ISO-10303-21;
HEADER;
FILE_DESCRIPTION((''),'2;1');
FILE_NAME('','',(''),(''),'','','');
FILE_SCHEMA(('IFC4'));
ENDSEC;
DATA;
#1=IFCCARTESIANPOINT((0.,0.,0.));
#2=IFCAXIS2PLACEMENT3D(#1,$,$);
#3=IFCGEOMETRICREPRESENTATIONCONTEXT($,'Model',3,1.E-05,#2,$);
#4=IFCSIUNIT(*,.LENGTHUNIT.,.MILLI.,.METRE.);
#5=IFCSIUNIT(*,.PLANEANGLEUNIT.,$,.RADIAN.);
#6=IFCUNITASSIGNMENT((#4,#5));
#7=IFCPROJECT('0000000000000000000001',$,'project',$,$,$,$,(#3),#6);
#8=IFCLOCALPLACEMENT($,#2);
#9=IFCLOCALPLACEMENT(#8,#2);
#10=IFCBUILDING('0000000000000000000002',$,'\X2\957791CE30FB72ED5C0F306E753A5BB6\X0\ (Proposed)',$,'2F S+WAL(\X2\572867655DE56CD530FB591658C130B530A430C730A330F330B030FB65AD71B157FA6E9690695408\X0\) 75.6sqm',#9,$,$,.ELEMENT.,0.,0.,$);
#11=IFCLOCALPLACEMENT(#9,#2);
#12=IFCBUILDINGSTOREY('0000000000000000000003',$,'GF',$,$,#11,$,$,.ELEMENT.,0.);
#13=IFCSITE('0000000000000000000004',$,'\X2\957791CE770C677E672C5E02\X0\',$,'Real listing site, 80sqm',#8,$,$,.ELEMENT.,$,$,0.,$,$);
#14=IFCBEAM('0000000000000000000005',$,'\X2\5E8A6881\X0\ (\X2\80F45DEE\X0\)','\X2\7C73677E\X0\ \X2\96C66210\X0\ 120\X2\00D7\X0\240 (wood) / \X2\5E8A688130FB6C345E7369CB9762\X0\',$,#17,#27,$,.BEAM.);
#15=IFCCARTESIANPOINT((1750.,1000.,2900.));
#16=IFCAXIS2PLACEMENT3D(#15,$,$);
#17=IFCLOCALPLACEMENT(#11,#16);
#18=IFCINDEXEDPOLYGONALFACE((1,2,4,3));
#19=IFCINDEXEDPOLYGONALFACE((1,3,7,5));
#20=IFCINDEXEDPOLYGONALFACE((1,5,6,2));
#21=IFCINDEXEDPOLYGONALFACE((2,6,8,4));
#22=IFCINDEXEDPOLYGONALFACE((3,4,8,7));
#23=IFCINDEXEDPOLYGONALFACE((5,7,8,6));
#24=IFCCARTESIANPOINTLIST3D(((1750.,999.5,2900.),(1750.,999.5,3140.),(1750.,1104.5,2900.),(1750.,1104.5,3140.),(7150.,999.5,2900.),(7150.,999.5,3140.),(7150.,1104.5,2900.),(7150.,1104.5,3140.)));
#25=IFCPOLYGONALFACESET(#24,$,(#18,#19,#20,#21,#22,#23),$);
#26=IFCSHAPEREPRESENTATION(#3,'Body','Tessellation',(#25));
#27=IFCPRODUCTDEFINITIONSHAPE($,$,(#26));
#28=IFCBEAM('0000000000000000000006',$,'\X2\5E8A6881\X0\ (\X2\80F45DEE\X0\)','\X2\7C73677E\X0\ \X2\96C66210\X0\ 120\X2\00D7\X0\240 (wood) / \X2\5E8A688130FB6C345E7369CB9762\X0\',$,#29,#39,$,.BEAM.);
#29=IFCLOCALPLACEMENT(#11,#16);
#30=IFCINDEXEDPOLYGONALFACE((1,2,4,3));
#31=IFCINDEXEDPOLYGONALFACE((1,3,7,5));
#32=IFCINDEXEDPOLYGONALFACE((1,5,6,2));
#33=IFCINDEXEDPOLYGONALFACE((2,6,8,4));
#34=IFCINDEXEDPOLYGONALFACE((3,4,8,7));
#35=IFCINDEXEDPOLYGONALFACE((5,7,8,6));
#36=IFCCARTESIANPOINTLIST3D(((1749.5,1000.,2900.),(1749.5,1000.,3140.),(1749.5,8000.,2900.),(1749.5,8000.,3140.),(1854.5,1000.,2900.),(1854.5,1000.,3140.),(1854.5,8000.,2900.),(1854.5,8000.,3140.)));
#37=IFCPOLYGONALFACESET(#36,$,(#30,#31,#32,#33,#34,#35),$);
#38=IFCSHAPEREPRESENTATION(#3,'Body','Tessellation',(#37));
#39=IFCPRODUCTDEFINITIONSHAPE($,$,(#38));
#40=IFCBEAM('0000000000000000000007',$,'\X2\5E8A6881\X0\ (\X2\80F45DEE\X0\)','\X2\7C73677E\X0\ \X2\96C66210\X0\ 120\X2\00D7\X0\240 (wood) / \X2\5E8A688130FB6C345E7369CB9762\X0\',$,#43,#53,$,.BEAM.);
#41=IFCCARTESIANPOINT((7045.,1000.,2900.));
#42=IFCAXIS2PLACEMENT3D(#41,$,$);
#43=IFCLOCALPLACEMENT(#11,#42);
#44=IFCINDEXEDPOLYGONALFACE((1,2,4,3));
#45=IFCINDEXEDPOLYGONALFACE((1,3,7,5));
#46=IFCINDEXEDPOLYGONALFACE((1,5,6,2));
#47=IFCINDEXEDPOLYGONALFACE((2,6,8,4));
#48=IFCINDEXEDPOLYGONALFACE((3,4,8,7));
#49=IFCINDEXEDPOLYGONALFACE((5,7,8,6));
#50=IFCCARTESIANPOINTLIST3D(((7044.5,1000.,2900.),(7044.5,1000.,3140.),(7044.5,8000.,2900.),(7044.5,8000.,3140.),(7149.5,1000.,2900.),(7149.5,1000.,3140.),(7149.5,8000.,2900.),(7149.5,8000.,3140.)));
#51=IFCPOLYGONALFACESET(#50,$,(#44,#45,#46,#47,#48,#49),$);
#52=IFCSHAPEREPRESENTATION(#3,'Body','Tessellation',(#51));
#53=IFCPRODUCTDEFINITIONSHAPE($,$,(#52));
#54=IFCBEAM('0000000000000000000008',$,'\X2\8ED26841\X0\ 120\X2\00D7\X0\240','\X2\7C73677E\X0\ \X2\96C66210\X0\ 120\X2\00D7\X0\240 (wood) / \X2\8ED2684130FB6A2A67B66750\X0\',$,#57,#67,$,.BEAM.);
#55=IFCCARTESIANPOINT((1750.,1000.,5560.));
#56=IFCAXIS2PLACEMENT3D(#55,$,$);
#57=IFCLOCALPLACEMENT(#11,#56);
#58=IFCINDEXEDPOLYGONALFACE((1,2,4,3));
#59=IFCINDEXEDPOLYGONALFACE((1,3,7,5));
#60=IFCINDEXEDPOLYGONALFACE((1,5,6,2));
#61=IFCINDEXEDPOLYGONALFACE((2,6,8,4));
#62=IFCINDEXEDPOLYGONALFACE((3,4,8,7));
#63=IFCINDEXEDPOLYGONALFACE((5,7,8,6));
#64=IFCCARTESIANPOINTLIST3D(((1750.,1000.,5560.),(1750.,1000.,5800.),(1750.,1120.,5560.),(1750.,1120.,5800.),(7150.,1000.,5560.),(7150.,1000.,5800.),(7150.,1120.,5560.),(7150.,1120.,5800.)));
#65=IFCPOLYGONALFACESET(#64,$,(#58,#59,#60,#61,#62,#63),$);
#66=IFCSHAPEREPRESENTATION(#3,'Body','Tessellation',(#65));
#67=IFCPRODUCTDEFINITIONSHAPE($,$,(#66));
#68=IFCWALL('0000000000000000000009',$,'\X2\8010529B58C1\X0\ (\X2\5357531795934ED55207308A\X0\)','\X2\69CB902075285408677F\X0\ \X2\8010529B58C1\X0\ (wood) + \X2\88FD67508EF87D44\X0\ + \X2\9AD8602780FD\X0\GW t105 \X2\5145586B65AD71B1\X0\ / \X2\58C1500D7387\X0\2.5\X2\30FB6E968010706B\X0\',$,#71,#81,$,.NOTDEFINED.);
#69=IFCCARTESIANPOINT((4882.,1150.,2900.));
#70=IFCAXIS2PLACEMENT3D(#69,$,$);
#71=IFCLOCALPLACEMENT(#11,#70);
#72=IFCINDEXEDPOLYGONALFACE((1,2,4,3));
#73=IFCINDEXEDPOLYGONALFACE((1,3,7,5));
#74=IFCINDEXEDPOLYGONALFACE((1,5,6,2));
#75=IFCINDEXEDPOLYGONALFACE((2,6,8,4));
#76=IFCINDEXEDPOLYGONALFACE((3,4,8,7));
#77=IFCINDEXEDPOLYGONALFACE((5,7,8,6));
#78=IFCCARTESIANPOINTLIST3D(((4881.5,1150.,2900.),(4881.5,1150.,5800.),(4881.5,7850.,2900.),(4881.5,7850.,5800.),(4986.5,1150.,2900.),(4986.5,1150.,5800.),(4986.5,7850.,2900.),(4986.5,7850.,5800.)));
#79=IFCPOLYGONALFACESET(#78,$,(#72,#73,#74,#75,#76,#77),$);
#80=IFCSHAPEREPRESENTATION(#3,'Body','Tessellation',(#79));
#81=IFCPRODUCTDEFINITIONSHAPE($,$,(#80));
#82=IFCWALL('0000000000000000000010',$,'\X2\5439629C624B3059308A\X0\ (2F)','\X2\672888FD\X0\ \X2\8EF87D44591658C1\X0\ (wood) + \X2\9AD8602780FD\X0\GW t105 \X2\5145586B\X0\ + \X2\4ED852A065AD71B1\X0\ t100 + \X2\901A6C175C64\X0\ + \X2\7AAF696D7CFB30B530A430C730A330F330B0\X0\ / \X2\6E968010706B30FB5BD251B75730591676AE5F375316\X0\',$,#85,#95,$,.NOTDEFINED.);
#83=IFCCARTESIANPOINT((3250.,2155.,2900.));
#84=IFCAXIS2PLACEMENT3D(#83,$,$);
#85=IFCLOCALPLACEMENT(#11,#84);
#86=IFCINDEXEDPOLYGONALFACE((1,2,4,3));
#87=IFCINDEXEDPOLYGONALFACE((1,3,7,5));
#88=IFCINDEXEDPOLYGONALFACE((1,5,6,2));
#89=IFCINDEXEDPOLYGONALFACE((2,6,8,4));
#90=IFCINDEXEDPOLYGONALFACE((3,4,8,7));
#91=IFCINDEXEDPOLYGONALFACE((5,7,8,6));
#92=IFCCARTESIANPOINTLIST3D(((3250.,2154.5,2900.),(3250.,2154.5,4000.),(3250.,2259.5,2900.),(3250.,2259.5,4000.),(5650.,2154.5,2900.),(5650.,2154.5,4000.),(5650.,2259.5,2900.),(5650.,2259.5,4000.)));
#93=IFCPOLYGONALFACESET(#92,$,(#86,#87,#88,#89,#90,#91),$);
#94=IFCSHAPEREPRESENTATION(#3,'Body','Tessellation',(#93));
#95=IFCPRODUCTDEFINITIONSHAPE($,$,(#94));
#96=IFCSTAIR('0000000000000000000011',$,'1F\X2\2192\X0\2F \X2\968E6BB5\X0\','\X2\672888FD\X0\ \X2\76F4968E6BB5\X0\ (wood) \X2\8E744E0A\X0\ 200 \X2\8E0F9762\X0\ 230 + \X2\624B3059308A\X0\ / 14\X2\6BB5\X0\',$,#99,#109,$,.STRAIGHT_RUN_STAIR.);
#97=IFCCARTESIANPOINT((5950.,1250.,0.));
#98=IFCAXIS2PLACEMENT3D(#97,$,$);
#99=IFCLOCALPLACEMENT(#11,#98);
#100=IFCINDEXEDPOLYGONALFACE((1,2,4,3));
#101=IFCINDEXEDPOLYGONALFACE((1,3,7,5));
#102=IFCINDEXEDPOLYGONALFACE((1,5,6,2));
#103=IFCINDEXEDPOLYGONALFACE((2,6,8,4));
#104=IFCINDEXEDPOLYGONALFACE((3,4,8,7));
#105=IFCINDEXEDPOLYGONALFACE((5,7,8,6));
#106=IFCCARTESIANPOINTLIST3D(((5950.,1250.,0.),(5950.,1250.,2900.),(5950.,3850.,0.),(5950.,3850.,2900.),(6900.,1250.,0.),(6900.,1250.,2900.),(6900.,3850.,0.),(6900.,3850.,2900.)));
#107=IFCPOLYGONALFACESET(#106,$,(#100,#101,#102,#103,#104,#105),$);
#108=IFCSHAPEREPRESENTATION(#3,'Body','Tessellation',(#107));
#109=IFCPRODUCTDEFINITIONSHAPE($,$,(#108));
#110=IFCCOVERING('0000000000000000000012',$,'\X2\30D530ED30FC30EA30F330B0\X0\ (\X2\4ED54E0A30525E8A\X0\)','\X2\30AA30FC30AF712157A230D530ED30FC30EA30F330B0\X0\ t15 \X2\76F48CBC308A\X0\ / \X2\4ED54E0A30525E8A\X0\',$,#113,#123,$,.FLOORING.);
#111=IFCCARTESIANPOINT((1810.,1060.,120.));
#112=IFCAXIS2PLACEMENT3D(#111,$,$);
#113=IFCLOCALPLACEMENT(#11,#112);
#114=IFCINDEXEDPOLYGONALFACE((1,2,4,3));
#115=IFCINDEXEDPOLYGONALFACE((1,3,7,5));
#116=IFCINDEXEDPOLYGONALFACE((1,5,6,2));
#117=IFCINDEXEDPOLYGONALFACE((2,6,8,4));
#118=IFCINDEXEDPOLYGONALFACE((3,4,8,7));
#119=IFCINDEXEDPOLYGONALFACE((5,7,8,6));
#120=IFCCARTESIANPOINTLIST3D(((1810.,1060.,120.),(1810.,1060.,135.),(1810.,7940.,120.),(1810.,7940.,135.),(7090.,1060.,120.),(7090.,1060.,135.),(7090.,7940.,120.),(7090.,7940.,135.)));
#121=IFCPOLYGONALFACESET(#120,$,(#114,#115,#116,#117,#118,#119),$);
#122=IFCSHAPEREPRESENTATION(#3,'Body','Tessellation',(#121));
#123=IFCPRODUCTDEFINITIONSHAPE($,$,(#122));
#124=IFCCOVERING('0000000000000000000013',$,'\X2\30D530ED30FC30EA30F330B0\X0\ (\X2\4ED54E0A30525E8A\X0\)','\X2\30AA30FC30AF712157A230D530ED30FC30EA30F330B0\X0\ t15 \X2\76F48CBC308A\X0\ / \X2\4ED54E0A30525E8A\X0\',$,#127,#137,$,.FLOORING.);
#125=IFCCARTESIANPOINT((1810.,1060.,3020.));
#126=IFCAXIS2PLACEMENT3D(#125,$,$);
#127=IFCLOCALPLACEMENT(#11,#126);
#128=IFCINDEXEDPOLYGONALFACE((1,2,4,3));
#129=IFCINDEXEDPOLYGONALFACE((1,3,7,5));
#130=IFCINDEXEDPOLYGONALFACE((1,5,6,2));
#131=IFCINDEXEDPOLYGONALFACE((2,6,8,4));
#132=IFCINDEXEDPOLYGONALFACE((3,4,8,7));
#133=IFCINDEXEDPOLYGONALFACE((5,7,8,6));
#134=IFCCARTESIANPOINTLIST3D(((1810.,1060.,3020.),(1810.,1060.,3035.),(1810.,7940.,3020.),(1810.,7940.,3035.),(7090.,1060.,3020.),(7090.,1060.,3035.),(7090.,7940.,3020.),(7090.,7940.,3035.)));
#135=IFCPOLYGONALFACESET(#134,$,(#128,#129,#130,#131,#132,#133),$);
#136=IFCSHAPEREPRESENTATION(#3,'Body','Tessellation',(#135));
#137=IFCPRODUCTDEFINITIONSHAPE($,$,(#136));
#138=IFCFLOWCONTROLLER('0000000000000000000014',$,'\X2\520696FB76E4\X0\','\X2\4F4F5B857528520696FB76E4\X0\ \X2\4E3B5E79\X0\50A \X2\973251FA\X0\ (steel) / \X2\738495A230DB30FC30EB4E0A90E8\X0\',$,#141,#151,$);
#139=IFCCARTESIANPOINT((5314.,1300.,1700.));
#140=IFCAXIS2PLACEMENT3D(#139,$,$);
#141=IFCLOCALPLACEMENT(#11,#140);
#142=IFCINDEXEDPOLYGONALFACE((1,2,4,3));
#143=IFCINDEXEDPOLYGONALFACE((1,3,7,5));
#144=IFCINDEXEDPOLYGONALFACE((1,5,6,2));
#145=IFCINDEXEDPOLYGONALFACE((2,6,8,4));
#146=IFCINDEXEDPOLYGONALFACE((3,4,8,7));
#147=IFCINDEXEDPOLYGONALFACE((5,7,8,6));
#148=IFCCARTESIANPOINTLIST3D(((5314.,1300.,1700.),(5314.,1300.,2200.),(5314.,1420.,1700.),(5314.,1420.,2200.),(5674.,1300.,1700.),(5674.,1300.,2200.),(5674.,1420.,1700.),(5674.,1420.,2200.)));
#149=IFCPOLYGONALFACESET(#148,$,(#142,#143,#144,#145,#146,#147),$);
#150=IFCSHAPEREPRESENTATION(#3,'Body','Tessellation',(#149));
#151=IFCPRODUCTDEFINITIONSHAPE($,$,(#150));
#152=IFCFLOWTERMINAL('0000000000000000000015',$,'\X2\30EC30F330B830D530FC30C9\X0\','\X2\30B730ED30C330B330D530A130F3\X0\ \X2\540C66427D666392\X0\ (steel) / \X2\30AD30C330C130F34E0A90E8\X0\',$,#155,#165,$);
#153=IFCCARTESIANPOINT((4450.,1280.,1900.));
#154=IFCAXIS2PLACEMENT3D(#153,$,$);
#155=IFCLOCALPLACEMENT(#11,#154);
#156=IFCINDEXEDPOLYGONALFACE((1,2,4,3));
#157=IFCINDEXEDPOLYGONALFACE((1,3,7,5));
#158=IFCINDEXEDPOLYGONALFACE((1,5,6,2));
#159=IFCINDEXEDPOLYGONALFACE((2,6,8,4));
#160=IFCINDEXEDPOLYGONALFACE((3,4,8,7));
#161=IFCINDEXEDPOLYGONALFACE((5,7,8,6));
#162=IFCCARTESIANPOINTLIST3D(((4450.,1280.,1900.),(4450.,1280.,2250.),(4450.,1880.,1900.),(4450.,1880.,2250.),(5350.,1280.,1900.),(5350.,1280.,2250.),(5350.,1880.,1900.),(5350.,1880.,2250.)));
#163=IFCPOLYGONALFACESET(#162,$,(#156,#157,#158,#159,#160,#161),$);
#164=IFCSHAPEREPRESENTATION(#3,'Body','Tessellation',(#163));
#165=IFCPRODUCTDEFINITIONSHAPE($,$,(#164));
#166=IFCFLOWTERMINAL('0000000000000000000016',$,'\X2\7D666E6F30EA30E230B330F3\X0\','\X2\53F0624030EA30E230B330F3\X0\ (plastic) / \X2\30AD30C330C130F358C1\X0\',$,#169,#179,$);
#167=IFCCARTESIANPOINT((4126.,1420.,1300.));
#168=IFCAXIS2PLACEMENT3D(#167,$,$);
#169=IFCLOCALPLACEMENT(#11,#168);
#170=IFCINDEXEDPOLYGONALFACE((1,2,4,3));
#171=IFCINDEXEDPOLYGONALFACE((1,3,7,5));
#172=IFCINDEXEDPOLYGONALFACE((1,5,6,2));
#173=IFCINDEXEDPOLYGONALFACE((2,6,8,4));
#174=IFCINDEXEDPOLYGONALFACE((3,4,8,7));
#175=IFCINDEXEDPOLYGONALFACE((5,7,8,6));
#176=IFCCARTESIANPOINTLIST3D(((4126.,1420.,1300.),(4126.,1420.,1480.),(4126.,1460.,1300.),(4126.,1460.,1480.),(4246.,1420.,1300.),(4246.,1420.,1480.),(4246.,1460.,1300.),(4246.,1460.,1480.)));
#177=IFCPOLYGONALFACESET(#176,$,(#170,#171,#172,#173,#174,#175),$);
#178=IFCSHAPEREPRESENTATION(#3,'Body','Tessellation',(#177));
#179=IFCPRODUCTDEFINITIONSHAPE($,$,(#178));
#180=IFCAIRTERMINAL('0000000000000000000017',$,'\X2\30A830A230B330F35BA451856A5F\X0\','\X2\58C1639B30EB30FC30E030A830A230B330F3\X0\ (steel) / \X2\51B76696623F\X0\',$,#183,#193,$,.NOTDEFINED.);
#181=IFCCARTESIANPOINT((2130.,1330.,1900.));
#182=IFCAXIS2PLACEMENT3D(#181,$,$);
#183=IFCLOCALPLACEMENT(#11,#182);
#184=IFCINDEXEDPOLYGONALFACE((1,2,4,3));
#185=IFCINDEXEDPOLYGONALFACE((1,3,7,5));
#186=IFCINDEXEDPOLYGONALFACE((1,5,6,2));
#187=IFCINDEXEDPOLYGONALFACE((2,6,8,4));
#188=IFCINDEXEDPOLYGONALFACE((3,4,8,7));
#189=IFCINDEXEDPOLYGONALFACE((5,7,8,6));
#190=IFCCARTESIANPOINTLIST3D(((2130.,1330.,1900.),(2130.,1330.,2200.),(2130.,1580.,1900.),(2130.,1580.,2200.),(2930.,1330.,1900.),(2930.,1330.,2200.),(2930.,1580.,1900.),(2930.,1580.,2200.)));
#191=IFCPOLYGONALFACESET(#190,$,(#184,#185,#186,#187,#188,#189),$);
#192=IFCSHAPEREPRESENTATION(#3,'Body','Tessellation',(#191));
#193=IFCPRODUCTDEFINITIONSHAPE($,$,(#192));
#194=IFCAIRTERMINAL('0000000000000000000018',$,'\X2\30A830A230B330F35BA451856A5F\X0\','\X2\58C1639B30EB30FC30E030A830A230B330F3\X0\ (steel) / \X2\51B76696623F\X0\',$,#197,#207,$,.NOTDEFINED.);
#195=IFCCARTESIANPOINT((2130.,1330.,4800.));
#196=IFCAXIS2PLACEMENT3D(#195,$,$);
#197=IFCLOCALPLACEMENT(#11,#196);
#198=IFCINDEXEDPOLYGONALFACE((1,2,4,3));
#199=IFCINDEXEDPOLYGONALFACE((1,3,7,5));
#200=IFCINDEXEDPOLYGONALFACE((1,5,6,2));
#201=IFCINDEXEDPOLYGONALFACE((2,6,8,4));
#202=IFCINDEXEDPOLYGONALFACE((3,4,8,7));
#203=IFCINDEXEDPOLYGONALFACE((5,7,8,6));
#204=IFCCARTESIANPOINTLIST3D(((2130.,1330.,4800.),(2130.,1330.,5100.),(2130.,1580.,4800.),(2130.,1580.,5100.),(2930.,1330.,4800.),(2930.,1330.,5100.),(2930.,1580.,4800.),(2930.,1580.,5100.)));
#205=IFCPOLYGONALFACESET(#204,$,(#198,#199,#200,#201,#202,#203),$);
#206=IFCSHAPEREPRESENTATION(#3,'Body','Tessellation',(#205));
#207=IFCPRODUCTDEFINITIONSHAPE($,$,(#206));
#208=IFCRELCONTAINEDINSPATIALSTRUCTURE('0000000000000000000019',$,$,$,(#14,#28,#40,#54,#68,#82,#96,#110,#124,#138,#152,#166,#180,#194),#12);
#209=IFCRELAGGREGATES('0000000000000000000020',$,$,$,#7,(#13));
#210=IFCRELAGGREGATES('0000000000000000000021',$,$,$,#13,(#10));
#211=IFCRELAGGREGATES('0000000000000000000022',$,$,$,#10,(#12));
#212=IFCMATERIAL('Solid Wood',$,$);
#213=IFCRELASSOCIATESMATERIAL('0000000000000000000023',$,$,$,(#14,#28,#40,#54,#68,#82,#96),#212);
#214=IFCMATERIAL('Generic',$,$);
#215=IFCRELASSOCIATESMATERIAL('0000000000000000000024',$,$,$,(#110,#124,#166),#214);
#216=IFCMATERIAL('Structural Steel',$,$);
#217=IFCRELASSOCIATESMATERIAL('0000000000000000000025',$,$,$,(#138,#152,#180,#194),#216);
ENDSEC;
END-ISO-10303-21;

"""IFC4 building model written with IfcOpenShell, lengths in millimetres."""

from ifc_helpers import new_model, si_unit, frame, frame_2d, origin, place, context, project, spatial, rectangle, extrude, material, element, save


model = new_model("IFC4")

# Units and contexts
model_context = context("Model", 3, precision=1e-05, world=origin())
ifc_project = project(units=[si_unit("LENGTHUNIT", "METRE", prefix="MILLI"), si_unit("PLANEANGLEUNIT", "RADIAN")], contexts=[model_context])

# Site, building, storey
site_placement = place(None, origin())
site = spatial("IfcSite", under=ifc_project, at=site_placement, Name="長野県松本市", ObjectType="Real listing site, 80sqm", CompositionType="ELEMENT", RefElevation=0.0)
building_placement = place(site_placement, origin())
building = spatial("IfcBuilding", under=site, at=building_placement, Name="長野・狭小の町家 (Proposed)", ObjectType="2F S+WAL(在来工法・外壁サイディング・断熱基準適合) 75.6sqm", CompositionType="ELEMENT", ElevationOfRefHeight=0.0, ElevationOfTerrain=0.0)
storey_placement = place(building_placement, origin())
storey = spatial("IfcBuildingStorey", under=building, at=storey_placement, Name="GF", CompositionType="ELEMENT", Elevation=0.0)

# Beams
ifc_material_1 = material(Name="Solid Wood")
beam_1_placement = place(storey_placement, frame((1750.0, 1000.0, 2900.0)))
element("IfcBeam", 1, at=beam_1_placement, inside=storey, material=ifc_material_1, Name="床梁 (胴差)", Description="米松 集成 120×240 (wood) / 床梁・水平構面", PredefinedType="BEAM", context=model_context, shape_type="SweptSolid", body=[
    extrude(rectangle(XDim=5400.0, YDim=105.0, at=frame_2d((2700.0, 52.0))), frame((1750.0, 1000.0, 2900.0)), (0.0, 0.0, 1.0), 240.0),
])
beam_2_placement = place(storey_placement, frame((1750.0, 1000.0, 2900.0)))
element("IfcBeam", 2, at=beam_2_placement, inside=storey, material=ifc_material_1, Name="床梁 (胴差)", Description="米松 集成 120×240 (wood) / 床梁・水平構面", PredefinedType="BEAM", context=model_context, shape_type="SweptSolid", body=[
    extrude(rectangle(XDim=105.0, YDim=7000.0, at=frame_2d((52.0, 3500.0))), frame((1750.0, 1000.0, 2900.0)), (0.0, 0.0, 1.0), 240.0),
])
beam_3_placement = place(storey_placement, frame((7045.0, 1000.0, 2900.0)))
element("IfcBeam", 3, at=beam_3_placement, inside=storey, material=ifc_material_1, Name="床梁 (胴差)", Description="米松 集成 120×240 (wood) / 床梁・水平構面", PredefinedType="BEAM", context=model_context, shape_type="SweptSolid", body=[
    extrude(rectangle(XDim=105.0, YDim=7000.0, at=frame_2d((52.0, 3500.0))), frame((7045.0, 1000.0, 2900.0)), (0.0, 0.0, 1.0), 240.0),
])
beam_4_placement = place(storey_placement, frame((1750.0, 1000.0, 5560.0)))
element("IfcBeam", 4, at=beam_4_placement, inside=storey, material=ifc_material_1, Name="軒桁 120×240", Description="米松 集成 120×240 (wood) / 軒桁・横架材", PredefinedType="BEAM", context=model_context, shape_type="SweptSolid", body=[
    extrude(rectangle(XDim=5400.0, YDim=120.0, at=frame_2d((2700.0, 60.0))), frame((1750.0, 1000.0, 5560.0)), (0.0, 0.0, 1.0), 240.0),
])

# Walls
wall_1_placement = place(storey_placement, frame((4882.0, 1150.0, 2900.0)))
element("IfcWall", 5, at=wall_1_placement, inside=storey, material=ifc_material_1, Name="耐力壁 (南北間仕切り)", Description="構造用合板 耐力壁 (wood) + 製材軸組 + 高性能GW t105 充填断熱 / 壁倍率2.5・準耐火", PredefinedType="NOTDEFINED", context=model_context, shape_type="SweptSolid", body=[
    extrude(rectangle(XDim=105.0, YDim=6700.0, at=frame_2d((52.0, 3350.0))), frame((4882.0, 1150.0, 2900.0)), (0.0, 0.0, 1.0), 2900.0),
])
wall_2_placement = place(storey_placement, frame((3250.0, 2155.0, 2900.0)))
element("IfcWall", 6, at=wall_2_placement, inside=storey, material=ifc_material_1, Name="吹抜手すり (2F)", Description="木製 軸組外壁 (wood) + 高性能GW t105 充填 + 付加断熱 t100 + 通気層 + 窯業系サイディング / 準耐火・寒冷地外皮強化", PredefinedType="NOTDEFINED", context=model_context, shape_type="SweptSolid", body=[
    extrude(rectangle(XDim=2400.0, YDim=105.0, at=frame_2d((1200.0, 52.0))), frame((3250.0, 2155.0, 2900.0)), (0.0, 0.0, 1.0), 1100.0),
])

# Stair
stair_placement = place(storey_placement, frame((5950.0, 1250.0, 0.0)))
element("IfcStair", 7, at=stair_placement, inside=storey, material=ifc_material_1, Name="1F→2F 階段", Description="木製 直階段 (wood) 蹴上 200 踏面 230 + 手すり / 14段", PredefinedType="STRAIGHT_RUN_STAIR", context=model_context, shape_type="SweptSolid", body=[
    extrude(rectangle(XDim=950.0, YDim=2600.0, at=frame_2d((475.0, 1300.0))), frame((5950.0, 1250.0, 0.0)), (0.0, 0.0, 1.0), 2900.0),
])

# Coverings
ifc_material_2 = material(Name="Generic")
covering_1_placement = place(storey_placement, frame((1810.0, 1060.0, 120.0)))
element("IfcCovering", 8, at=covering_1_placement, inside=storey, material=ifc_material_2, Name="フローリング (仕上げ床)", Description="オーク無垢フローリング t15 直貼り / 仕上げ床", PredefinedType="FLOORING", context=model_context, shape_type="SweptSolid", body=[
    extrude(rectangle(XDim=5280.0, YDim=6880.0, at=frame_2d((2640.0, 3440.0))), frame((1810.0, 1060.0, 120.0)), (0.0, 0.0, 1.0), 15.0),
])
covering_2_placement = place(storey_placement, frame((1810.0, 1060.0, 3020.0)))
element("IfcCovering", 9, at=covering_2_placement, inside=storey, material=ifc_material_2, Name="フローリング (仕上げ床)", Description="オーク無垢フローリング t15 直貼り / 仕上げ床", PredefinedType="FLOORING", context=model_context, shape_type="SweptSolid", body=[
    extrude(rectangle(XDim=5280.0, YDim=6880.0, at=frame_2d((2640.0, 3440.0))), frame((1810.0, 1060.0, 3020.0)), (0.0, 0.0, 1.0), 15.0),
])

# Flow controller
ifc_material_3 = material(Name="Structural Steel")
flow_controller_placement = place(storey_placement, frame((5314.0, 1300.0, 1700.0)))
element("IfcFlowController", 10, at=flow_controller_placement, inside=storey, material=ifc_material_3, Name="分電盤", Description="住宅用分電盤 主幹50A 露出 (steel) / 玄関ホール上部", context=model_context, shape_type="SweptSolid", body=[
    extrude(rectangle(XDim=360.0, YDim=120.0, at=frame_2d((180.0, 60.0))), frame((5314.0, 1300.0, 1700.0)), (0.0, 0.0, 1.0), 500.0),
])

# Flow terminals
flow_terminal_1_placement = place(storey_placement, frame((4450.0, 1280.0, 1900.0)))
element("IfcFlowTerminal", 11, at=flow_terminal_1_placement, inside=storey, material=ifc_material_3, Name="レンジフード", Description="シロッコファン 同時給排 (steel) / キッチン上部", context=model_context, shape_type="SweptSolid", body=[
    extrude(rectangle(XDim=900.0, YDim=600.0, at=frame_2d((450.0, 300.0))), frame((4450.0, 1280.0, 1900.0)), (0.0, 0.0, 1.0), 350.0),
])
flow_terminal_2_placement = place(storey_placement, frame((4126.0, 1420.0, 1300.0)))
element("IfcFlowTerminal", 12, at=flow_terminal_2_placement, inside=storey, material=ifc_material_2, Name="給湯リモコン", Description="台所リモコン (plastic) / キッチン壁", context=model_context, shape_type="SweptSolid", body=[
    extrude(rectangle(XDim=120.0, YDim=40.0, at=frame_2d((60.0, 20.0))), frame((4126.0, 1420.0, 1300.0)), (0.0, 0.0, 1.0), 180.0),
])

# Air terminals
air_terminal_1_placement = place(storey_placement, frame((2130.0, 1330.0, 1900.0)))
element("IfcAirTerminal", 13, at=air_terminal_1_placement, inside=storey, material=ifc_material_3, Name="エアコン室内機", Description="壁掛ルームエアコン (steel) / 冷暖房", PredefinedType="NOTDEFINED", context=model_context, shape_type="SweptSolid", body=[
    extrude(rectangle(XDim=800.0, YDim=250.0, at=frame_2d((400.0, 125.0))), frame((2130.0, 1330.0, 1900.0)), (0.0, 0.0, 1.0), 300.0),
])
air_terminal_2_placement = place(storey_placement, frame((2130.0, 1330.0, 4800.0)))
element("IfcAirTerminal", 14, at=air_terminal_2_placement, inside=storey, material=ifc_material_3, Name="エアコン室内機", Description="壁掛ルームエアコン (steel) / 冷暖房", PredefinedType="NOTDEFINED", context=model_context, shape_type="SweptSolid", body=[
    extrude(rectangle(XDim=800.0, YDim=250.0, at=frame_2d((400.0, 125.0))), frame((2130.0, 1330.0, 4800.0)), (0.0, 0.0, 1.0), 300.0),
])

save(model, "model.ifc")
